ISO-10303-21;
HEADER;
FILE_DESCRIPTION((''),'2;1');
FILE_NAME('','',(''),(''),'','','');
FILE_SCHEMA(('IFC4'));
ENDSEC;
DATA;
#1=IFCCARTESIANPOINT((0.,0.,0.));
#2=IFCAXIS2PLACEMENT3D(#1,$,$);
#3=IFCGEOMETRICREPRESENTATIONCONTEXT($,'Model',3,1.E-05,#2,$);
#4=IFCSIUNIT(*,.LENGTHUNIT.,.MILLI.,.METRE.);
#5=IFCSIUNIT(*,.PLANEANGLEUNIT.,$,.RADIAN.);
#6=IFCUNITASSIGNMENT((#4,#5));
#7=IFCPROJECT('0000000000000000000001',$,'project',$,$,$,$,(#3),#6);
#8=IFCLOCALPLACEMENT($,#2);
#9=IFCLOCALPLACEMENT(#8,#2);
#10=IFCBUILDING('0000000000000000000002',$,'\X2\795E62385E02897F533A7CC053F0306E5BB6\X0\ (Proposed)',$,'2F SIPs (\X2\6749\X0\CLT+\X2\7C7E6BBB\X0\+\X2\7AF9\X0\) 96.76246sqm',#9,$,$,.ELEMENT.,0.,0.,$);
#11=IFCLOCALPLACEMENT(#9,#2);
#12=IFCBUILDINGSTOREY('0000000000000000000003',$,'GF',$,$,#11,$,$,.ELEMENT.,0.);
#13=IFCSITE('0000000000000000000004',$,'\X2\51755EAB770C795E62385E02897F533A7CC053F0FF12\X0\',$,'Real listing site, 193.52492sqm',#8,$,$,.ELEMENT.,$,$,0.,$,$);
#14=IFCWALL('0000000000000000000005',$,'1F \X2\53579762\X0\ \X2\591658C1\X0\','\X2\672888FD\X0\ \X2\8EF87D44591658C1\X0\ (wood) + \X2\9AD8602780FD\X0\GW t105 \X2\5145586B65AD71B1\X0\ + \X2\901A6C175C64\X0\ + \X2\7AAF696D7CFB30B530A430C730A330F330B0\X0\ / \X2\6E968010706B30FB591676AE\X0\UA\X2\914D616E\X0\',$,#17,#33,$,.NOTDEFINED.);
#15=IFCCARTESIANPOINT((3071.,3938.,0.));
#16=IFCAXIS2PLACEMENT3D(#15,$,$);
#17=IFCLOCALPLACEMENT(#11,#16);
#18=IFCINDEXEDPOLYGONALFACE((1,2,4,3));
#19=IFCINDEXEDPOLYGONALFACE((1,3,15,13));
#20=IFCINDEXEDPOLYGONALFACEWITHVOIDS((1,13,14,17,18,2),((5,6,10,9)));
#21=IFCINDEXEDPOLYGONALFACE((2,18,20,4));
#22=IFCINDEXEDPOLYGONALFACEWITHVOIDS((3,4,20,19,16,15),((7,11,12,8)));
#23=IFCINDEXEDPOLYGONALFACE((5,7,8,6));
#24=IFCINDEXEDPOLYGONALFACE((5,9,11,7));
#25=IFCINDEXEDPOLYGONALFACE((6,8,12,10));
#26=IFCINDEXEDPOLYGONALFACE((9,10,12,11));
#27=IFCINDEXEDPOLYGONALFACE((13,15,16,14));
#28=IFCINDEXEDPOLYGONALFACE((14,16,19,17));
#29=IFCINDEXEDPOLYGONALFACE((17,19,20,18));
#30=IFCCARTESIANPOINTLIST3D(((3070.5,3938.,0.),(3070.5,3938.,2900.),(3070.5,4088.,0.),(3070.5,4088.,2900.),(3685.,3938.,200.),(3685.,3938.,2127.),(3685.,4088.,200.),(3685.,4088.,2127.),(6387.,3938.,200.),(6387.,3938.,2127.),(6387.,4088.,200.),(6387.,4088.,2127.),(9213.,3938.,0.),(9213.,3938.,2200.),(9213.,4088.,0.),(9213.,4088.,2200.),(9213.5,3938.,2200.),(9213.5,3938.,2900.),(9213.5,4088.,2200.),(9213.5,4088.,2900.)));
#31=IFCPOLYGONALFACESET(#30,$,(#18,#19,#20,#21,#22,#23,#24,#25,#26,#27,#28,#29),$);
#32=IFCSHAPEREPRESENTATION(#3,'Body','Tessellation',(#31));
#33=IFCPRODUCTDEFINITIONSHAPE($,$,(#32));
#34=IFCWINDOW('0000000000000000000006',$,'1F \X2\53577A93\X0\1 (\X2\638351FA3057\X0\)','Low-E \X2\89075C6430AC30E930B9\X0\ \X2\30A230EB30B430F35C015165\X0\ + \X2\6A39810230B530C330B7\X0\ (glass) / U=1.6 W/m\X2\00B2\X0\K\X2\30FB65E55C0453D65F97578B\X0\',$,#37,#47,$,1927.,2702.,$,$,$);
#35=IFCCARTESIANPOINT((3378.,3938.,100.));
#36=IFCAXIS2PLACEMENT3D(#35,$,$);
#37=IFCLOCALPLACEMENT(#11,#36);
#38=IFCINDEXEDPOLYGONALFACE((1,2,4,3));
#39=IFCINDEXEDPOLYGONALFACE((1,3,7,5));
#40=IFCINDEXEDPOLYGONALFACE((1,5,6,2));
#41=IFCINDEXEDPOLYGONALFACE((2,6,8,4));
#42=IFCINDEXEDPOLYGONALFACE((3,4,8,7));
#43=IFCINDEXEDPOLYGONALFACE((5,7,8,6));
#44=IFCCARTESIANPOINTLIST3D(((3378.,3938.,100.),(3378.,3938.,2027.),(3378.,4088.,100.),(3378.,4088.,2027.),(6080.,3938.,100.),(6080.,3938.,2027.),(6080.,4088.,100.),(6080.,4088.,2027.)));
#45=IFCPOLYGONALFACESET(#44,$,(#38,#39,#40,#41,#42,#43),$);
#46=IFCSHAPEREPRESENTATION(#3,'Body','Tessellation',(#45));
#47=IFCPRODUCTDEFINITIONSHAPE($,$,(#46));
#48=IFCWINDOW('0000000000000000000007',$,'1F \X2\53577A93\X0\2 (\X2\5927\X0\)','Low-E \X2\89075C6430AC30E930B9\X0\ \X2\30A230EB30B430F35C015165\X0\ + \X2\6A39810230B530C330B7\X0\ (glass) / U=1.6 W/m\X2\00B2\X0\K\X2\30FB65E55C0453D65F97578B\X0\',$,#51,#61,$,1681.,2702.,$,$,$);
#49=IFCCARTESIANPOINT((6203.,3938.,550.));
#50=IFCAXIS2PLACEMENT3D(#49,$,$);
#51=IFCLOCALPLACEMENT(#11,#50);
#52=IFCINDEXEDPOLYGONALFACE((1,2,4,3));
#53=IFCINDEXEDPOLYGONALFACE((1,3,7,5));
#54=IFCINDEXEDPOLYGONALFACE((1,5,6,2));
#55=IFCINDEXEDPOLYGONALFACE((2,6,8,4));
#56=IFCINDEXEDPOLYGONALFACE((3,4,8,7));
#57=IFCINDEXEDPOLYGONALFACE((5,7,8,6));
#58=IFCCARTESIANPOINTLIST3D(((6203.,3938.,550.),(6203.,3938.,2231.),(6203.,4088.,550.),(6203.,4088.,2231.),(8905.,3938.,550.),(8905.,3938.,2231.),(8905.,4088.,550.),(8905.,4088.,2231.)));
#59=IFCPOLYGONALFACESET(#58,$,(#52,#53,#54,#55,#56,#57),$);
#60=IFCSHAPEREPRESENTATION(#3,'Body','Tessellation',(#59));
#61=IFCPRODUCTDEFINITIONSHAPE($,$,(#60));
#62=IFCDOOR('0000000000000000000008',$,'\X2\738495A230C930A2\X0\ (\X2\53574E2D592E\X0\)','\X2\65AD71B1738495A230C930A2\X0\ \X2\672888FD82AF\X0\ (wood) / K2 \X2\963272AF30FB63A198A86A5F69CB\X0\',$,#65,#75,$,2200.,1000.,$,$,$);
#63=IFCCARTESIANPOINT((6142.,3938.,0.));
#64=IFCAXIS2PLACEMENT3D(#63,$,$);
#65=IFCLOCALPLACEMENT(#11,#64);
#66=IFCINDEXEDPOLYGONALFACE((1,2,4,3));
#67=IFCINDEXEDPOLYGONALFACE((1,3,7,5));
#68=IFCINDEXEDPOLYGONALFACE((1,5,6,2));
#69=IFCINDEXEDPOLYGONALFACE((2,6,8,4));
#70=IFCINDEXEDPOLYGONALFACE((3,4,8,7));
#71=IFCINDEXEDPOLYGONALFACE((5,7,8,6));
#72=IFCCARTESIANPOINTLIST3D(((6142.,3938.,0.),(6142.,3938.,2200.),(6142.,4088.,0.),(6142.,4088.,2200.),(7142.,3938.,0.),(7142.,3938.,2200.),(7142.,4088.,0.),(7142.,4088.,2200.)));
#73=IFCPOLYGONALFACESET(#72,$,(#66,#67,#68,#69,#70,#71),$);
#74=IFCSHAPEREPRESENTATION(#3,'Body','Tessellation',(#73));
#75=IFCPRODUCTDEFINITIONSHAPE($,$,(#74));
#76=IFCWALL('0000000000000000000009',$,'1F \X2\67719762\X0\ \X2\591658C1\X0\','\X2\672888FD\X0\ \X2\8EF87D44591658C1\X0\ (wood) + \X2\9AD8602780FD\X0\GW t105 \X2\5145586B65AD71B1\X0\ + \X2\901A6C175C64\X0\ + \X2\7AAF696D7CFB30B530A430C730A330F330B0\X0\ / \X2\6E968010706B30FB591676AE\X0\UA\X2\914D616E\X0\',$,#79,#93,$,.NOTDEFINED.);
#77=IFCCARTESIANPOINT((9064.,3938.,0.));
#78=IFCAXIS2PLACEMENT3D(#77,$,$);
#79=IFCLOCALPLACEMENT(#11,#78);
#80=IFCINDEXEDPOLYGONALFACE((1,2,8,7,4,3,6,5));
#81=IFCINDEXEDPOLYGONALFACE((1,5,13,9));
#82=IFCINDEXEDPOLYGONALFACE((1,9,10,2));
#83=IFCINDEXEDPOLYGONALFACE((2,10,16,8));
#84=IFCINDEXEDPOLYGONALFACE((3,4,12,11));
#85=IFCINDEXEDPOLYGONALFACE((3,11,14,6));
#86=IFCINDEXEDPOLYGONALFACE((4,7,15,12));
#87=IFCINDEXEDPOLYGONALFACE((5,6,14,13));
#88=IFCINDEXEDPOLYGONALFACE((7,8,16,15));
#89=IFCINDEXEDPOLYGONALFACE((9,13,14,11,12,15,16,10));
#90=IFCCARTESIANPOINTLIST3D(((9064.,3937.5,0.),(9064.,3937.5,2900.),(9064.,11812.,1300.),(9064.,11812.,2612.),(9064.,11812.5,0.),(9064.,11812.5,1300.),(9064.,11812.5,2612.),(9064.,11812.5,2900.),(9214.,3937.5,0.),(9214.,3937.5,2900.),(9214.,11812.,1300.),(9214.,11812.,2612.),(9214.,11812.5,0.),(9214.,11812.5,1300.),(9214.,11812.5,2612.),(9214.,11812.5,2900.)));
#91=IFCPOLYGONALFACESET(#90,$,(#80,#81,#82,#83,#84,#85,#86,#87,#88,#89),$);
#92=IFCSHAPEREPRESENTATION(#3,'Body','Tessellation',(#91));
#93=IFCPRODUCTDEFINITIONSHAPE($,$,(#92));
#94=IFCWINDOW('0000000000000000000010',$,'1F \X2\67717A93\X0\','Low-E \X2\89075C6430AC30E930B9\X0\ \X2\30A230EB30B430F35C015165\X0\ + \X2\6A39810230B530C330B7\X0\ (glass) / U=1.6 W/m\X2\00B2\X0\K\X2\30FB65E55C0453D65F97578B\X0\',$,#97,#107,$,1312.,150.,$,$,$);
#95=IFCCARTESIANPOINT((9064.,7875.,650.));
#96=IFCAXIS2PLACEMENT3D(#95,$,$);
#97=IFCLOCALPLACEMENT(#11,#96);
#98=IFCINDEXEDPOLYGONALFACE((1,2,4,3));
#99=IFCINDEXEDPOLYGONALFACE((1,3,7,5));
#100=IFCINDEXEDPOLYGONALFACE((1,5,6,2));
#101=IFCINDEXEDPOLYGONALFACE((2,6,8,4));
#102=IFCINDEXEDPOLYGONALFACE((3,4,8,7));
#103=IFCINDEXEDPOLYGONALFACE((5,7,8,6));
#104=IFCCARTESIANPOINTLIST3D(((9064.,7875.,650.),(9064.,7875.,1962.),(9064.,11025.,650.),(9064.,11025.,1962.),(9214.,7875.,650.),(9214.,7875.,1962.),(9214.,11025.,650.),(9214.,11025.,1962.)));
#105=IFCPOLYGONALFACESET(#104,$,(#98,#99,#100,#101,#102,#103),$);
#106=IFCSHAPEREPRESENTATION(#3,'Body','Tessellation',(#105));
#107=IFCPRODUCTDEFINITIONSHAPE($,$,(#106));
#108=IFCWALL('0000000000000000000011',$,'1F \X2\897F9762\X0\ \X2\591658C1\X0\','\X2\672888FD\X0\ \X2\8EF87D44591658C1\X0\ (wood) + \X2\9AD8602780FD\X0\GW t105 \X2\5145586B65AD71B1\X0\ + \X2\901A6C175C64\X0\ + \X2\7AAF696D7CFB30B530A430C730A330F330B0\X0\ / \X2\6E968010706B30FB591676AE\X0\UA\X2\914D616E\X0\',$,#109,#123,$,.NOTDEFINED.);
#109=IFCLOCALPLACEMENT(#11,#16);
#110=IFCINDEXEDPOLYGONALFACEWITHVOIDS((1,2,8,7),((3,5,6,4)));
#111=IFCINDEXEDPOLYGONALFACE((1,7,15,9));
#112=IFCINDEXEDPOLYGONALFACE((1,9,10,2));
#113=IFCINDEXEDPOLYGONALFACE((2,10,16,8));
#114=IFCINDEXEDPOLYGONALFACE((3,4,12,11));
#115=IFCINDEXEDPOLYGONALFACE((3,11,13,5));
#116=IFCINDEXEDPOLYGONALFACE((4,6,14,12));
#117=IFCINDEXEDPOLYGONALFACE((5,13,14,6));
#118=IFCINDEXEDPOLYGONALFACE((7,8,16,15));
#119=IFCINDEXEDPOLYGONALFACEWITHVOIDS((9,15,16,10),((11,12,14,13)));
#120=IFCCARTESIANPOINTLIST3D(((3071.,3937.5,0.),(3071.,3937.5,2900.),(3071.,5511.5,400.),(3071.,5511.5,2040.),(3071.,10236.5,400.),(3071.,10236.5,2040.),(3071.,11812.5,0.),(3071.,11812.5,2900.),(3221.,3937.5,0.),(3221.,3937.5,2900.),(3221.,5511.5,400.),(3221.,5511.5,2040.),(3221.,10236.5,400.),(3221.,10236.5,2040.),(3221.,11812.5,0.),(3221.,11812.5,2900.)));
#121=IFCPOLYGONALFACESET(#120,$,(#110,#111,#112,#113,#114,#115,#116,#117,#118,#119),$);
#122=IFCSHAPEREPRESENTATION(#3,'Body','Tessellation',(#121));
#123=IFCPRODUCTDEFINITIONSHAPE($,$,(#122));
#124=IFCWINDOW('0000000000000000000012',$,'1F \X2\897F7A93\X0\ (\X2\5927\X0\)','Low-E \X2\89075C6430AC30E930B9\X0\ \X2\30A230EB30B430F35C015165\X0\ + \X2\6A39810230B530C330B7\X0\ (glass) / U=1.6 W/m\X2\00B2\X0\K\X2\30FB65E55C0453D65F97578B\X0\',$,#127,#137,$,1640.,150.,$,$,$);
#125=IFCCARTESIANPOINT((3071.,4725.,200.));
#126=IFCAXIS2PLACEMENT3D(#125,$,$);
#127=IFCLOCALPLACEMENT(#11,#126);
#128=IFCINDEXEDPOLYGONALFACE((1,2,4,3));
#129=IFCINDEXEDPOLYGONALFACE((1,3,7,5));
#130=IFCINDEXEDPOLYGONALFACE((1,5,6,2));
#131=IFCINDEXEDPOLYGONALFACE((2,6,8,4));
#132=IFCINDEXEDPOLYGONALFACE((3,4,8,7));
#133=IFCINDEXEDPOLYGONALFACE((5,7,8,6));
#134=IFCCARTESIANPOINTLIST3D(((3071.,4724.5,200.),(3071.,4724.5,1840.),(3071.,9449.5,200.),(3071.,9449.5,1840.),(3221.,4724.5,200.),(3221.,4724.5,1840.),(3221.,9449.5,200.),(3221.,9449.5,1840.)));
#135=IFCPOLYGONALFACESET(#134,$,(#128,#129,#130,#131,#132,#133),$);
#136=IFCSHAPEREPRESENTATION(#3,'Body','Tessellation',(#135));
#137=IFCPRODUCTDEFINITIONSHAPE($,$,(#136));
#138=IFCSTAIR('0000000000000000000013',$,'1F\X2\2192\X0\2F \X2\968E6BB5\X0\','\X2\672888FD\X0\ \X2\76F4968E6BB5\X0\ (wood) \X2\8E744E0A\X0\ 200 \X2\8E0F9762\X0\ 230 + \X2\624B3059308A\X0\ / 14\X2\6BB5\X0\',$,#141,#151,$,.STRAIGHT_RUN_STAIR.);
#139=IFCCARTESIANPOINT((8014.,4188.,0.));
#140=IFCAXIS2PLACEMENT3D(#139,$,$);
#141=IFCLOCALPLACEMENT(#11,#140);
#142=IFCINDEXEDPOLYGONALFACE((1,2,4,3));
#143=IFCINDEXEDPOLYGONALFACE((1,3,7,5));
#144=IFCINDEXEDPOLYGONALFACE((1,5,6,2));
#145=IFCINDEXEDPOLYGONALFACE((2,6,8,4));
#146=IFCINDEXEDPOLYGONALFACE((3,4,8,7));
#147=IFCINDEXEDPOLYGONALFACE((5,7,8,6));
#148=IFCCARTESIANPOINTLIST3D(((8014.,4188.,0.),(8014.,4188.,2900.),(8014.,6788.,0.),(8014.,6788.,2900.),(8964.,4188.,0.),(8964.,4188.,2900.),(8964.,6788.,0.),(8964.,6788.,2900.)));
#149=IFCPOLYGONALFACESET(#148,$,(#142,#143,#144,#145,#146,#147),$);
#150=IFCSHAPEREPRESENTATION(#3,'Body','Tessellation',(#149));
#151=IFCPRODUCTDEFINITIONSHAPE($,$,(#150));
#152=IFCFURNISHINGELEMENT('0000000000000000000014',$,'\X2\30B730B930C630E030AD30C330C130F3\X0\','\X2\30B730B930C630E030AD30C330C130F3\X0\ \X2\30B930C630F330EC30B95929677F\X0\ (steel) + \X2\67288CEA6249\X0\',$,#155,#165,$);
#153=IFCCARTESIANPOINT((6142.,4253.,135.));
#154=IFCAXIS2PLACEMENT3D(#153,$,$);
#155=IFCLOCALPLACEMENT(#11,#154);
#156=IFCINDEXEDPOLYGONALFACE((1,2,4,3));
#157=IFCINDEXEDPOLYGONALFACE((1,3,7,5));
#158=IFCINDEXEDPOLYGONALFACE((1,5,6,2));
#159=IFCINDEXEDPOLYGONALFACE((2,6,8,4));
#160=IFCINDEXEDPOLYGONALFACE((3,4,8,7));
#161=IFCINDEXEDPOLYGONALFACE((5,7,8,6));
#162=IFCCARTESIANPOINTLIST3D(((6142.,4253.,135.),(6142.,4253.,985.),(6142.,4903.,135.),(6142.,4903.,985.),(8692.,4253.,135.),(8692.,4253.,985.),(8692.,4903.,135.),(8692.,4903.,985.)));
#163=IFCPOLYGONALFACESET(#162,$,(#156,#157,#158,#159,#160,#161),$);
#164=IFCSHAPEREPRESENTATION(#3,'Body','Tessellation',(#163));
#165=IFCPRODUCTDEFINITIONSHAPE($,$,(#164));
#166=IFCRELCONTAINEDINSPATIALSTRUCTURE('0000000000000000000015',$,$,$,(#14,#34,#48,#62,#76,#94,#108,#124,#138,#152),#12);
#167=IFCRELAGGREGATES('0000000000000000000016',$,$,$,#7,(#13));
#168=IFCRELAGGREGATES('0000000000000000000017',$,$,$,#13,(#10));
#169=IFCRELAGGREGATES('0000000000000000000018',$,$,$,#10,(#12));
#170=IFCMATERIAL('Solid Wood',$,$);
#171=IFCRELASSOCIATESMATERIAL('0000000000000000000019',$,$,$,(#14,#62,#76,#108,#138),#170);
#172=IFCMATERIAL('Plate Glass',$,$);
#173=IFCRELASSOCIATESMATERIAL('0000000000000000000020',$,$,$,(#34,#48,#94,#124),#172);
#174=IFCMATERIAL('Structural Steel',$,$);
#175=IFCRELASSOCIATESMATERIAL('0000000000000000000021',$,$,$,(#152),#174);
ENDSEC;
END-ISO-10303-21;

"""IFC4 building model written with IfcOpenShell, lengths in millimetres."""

from ifc_helpers import new_model, si_unit, frame, frame_2d, origin, place, context, project, spatial, rectangle, extrude, material, element, fill, save


model = new_model("IFC4")

# Units and contexts
model_context = context("Model", 3, precision=1e-05, world=origin())
ifc_project = project(units=[si_unit("LENGTHUNIT", "METRE", prefix="MILLI"), si_unit("PLANEANGLEUNIT", "RADIAN")], contexts=[model_context])

# Site, building, storey
site_placement = place(None, origin())
site = spatial("IfcSite", under=ifc_project, at=site_placement, Name="兵庫県神戸市西区糀台２", ObjectType="Real listing site, 193.52492sqm", CompositionType="ELEMENT", RefElevation=0.0)
building_placement = place(site_placement, origin())
building = spatial("IfcBuilding", under=site, at=building_placement, Name="神戸市西区糀台の家 (Proposed)", ObjectType="2F SIPs (杉CLT+籾殻+竹) 96.76246sqm", CompositionType="ELEMENT", ElevationOfRefHeight=0.0, ElevationOfTerrain=0.0)
storey_placement = place(building_placement, origin())
storey = spatial("IfcBuildingStorey", under=building, at=storey_placement, Name="GF", CompositionType="ELEMENT", Elevation=0.0)

# Shared definitions
ifc_material_1 = material(Name="Solid Wood")

# Wall, openings, windows, door
wall_1_placement = place(storey_placement, frame((3071.0, 3938.0, 0.0)))
wall_1 = element("IfcWall", 1, at=wall_1_placement, inside=storey, material=ifc_material_1, Name="1F 南面 外壁", Description="木製 軸組外壁 (wood) + 高性能GW t105 充填断熱 + 通気層 + 窯業系サイディング / 準耐火・外皮UA配慮", PredefinedType="NOTDEFINED", context=model_context, shape_type="SweptSolid", body=[
    extrude(rectangle(XDim=6143.0, YDim=150.0, at=frame_2d((3071.0, 75.0))), frame((3071.0, 3938.0, 0.0)), (0.0, 0.0, 1.0), 2900.0),
])
opening_1_placement = place(storey_placement, frame((3378.0, 3938.0, 100.0)))
opening_1 = element("IfcOpeningElement", 2, at=opening_1_placement, cuts=wall_1, PredefinedType="NOTDEFINED", context=model_context, shape_type="SweptSolid", body=[
    extrude(rectangle(XDim=2702.0, YDim=150.0, at=frame_2d((1351.0, 75.0))), frame((3378.0, 3938.0, 100.0)), (0.0, 0.0, 1.0), 1927.0),
])
opening_2_placement = place(storey_placement, frame((6203.0, 3938.0, 550.0)))
opening_2 = element("IfcOpeningElement", 3, at=opening_2_placement, cuts=wall_1, PredefinedType="NOTDEFINED", context=model_context, shape_type="SweptSolid", body=[
    extrude(rectangle(XDim=2702.0, YDim=150.0, at=frame_2d((1351.0, 75.0))), frame((6203.0, 3938.0, 550.0)), (0.0, 0.0, 1.0), 1681.0),
])
opening_3_placement = place(storey_placement, frame((6142.0, 3938.0, 0.0)))
opening_3 = element("IfcOpeningElement", 4, at=opening_3_placement, cuts=wall_1, PredefinedType="NOTDEFINED", context=model_context, shape_type="SweptSolid", body=[
    extrude(rectangle(XDim=1000.0, YDim=150.0, at=frame_2d((500.0, 75.0))), frame((6142.0, 3938.0, 0.0)), (0.0, 0.0, 1.0), 2200.0),
])
ifc_material_2 = material(Name="Plate Glass")
window_1_placement = place(storey_placement, frame((3378.0, 3938.0, 100.0)))
window_1 = element("IfcWindow", 5, at=window_1_placement, inside=storey, material=ifc_material_2, Name="1F 南窓1 (掃出し)", Description="Low-E 複層ガラス アルゴン封入 + 樹脂サッシ (glass) / U=1.6 W/m²K・日射取得型", OverallHeight=1927.0, OverallWidth=2702.0, context=model_context, shape_type="SweptSolid", body=[
    extrude(rectangle(XDim=2702.0, YDim=150.0, at=frame_2d((1351.0, 75.0))), frame((3378.0, 3938.0, 100.0)), (0.0, 0.0, 1.0), 1927.0),
])
fill(opening_1, window_1)
window_2_placement = place(storey_placement, frame((6203.0, 3938.0, 550.0)))
window_2 = element("IfcWindow", 6, at=window_2_placement, inside=storey, material=ifc_material_2, Name="1F 南窓2 (大)", Description="Low-E 複層ガラス アルゴン封入 + 樹脂サッシ (glass) / U=1.6 W/m²K・日射取得型", OverallHeight=1681.0, OverallWidth=2702.0, context=model_context, shape_type="SweptSolid", body=[
    extrude(rectangle(XDim=2702.0, YDim=150.0, at=frame_2d((1351.0, 75.0))), frame((6203.0, 3938.0, 550.0)), (0.0, 0.0, 1.0), 1681.0),
])
fill(opening_2, window_2)
door_placement = place(storey_placement, frame((6142.0, 3938.0, 0.0)))
door = element("IfcDoor", 7, at=door_placement, inside=storey, material=ifc_material_1, Name="玄関ドア (南中央)", Description="断熱玄関ドア 木製芯 (wood) / K2 防犯・採風機構", OverallHeight=2200.0, OverallWidth=1000.0, context=model_context, shape_type="SweptSolid", body=[
    extrude(rectangle(XDim=1000.0, YDim=150.0, at=frame_2d((500.0, 75.0))), frame((6142.0, 3938.0, 0.0)), (0.0, 0.0, 1.0), 2200.0),
])
fill(opening_3, door)

# Walls, openings, windows
wall_2_placement = place(storey_placement, frame((9064.0, 3938.0, 0.0)))
wall_2 = element("IfcWall", 8, at=wall_2_placement, inside=storey, material=ifc_material_1, Name="1F 東面 外壁", Description="木製 軸組外壁 (wood) + 高性能GW t105 充填断熱 + 通気層 + 窯業系サイディング / 準耐火・外皮UA配慮", PredefinedType="NOTDEFINED", context=model_context, shape_type="SweptSolid", body=[
    extrude(rectangle(XDim=150.0, YDim=7875.0, at=frame_2d((75.0, 3937.0))), frame((9064.0, 3938.0, 0.0)), (0.0, 0.0, 1.0), 2900.0),
])
opening_4_placement = place(storey_placement, frame((9064.0, 7875.0, 650.0)))
opening_4 = element("IfcOpeningElement", 9, at=opening_4_placement, cuts=wall_2, PredefinedType="NOTDEFINED", context=model_context, shape_type="SweptSolid", body=[
    extrude(rectangle(XDim=150.0, YDim=3150.0, at=frame_2d((75.0, 1575.0))), frame((9064.0, 7875.0, 650.0)), (0.0, 0.0, 1.0), 1312.0),
])
window_3_placement = place(storey_placement, frame((9064.0, 7875.0, 650.0)))
window_3 = element("IfcWindow", 10, at=window_3_placement, inside=storey, material=ifc_material_2, Name="1F 東窓", Description="Low-E 複層ガラス アルゴン封入 + 樹脂サッシ (glass) / U=1.6 W/m²K・日射取得型", OverallHeight=1312.0, OverallWidth=150.0, context=model_context, shape_type="SweptSolid", body=[
    extrude(rectangle(XDim=150.0, YDim=3150.0, at=frame_2d((75.0, 1575.0))), frame((9064.0, 7875.0, 650.0)), (0.0, 0.0, 1.0), 1312.0),
])
fill(opening_4, window_3)
wall_3_placement = place(storey_placement, frame((3071.0, 3938.0, 0.0)))
wall_3 = element("IfcWall", 11, at=wall_3_placement, inside=storey, material=ifc_material_1, Name="1F 西面 外壁", Description="木製 軸組外壁 (wood) + 高性能GW t105 充填断熱 + 通気層 + 窯業系サイディング / 準耐火・外皮UA配慮", PredefinedType="NOTDEFINED", context=model_context, shape_type="SweptSolid", body=[
    extrude(rectangle(XDim=150.0, YDim=7875.0, at=frame_2d((75.0, 3937.0))), frame((3071.0, 3938.0, 0.0)), (0.0, 0.0, 1.0), 2900.0),
])
opening_5_placement = place(storey_placement, frame((3071.0, 4725.0, 200.0)))
opening_5 = element("IfcOpeningElement", 12, at=opening_5_placement, cuts=wall_3, PredefinedType="NOTDEFINED", context=model_context, shape_type="SweptSolid", body=[
    extrude(rectangle(XDim=150.0, YDim=4725.0, at=frame_2d((75.0, 2362.0))), frame((3071.0, 4725.0, 200.0)), (0.0, 0.0, 1.0), 1640.0),
])
window_4_placement = place(storey_placement, frame((3071.0, 4725.0, 200.0)))
window_4 = element("IfcWindow", 13, at=window_4_placement, inside=storey, material=ifc_material_2, Name="1F 西窓 (大)", Description="Low-E 複層ガラス アルゴン封入 + 樹脂サッシ (glass) / U=1.6 W/m²K・日射取得型", OverallHeight=1640.0, OverallWidth=150.0, context=model_context, shape_type="SweptSolid", body=[
    extrude(rectangle(XDim=150.0, YDim=4725.0, at=frame_2d((75.0, 2362.0))), frame((3071.0, 4725.0, 200.0)), (0.0, 0.0, 1.0), 1640.0),
])
fill(opening_5, window_4)

# Stair
stair_placement = place(storey_placement, frame((8014.0, 4188.0, 0.0)))
element("IfcStair", 14, at=stair_placement, inside=storey, material=ifc_material_1, Name="1F→2F 階段", Description="木製 直階段 (wood) 蹴上 200 踏面 230 + 手すり / 14段", PredefinedType="STRAIGHT_RUN_STAIR", context=model_context, shape_type="SweptSolid", body=[
    extrude(rectangle(XDim=950.0, YDim=2600.0, at=frame_2d((475.0, 1300.0))), frame((8014.0, 4188.0, 0.0)), (0.0, 0.0, 1.0), 2900.0),
])

# Furnishing element
ifc_material_3 = material(Name="Structural Steel")
furnishing_placement = place(storey_placement, frame((6142.0, 4253.0, 135.0)))
element("IfcFurnishingElement", 15, at=furnishing_placement, inside=storey, material=ifc_material_3, Name="システムキッチン", Description="システムキッチン ステンレス天板 (steel) + 木質扉", context=model_context, shape_type="SweptSolid", body=[
    extrude(rectangle(XDim=2550.0, YDim=650.0, at=frame_2d((1275.0, 325.0))), frame((6142.0, 4253.0, 135.0)), (0.0, 0.0, 1.0), 850.0),
])

save(model, "model.ifc")
